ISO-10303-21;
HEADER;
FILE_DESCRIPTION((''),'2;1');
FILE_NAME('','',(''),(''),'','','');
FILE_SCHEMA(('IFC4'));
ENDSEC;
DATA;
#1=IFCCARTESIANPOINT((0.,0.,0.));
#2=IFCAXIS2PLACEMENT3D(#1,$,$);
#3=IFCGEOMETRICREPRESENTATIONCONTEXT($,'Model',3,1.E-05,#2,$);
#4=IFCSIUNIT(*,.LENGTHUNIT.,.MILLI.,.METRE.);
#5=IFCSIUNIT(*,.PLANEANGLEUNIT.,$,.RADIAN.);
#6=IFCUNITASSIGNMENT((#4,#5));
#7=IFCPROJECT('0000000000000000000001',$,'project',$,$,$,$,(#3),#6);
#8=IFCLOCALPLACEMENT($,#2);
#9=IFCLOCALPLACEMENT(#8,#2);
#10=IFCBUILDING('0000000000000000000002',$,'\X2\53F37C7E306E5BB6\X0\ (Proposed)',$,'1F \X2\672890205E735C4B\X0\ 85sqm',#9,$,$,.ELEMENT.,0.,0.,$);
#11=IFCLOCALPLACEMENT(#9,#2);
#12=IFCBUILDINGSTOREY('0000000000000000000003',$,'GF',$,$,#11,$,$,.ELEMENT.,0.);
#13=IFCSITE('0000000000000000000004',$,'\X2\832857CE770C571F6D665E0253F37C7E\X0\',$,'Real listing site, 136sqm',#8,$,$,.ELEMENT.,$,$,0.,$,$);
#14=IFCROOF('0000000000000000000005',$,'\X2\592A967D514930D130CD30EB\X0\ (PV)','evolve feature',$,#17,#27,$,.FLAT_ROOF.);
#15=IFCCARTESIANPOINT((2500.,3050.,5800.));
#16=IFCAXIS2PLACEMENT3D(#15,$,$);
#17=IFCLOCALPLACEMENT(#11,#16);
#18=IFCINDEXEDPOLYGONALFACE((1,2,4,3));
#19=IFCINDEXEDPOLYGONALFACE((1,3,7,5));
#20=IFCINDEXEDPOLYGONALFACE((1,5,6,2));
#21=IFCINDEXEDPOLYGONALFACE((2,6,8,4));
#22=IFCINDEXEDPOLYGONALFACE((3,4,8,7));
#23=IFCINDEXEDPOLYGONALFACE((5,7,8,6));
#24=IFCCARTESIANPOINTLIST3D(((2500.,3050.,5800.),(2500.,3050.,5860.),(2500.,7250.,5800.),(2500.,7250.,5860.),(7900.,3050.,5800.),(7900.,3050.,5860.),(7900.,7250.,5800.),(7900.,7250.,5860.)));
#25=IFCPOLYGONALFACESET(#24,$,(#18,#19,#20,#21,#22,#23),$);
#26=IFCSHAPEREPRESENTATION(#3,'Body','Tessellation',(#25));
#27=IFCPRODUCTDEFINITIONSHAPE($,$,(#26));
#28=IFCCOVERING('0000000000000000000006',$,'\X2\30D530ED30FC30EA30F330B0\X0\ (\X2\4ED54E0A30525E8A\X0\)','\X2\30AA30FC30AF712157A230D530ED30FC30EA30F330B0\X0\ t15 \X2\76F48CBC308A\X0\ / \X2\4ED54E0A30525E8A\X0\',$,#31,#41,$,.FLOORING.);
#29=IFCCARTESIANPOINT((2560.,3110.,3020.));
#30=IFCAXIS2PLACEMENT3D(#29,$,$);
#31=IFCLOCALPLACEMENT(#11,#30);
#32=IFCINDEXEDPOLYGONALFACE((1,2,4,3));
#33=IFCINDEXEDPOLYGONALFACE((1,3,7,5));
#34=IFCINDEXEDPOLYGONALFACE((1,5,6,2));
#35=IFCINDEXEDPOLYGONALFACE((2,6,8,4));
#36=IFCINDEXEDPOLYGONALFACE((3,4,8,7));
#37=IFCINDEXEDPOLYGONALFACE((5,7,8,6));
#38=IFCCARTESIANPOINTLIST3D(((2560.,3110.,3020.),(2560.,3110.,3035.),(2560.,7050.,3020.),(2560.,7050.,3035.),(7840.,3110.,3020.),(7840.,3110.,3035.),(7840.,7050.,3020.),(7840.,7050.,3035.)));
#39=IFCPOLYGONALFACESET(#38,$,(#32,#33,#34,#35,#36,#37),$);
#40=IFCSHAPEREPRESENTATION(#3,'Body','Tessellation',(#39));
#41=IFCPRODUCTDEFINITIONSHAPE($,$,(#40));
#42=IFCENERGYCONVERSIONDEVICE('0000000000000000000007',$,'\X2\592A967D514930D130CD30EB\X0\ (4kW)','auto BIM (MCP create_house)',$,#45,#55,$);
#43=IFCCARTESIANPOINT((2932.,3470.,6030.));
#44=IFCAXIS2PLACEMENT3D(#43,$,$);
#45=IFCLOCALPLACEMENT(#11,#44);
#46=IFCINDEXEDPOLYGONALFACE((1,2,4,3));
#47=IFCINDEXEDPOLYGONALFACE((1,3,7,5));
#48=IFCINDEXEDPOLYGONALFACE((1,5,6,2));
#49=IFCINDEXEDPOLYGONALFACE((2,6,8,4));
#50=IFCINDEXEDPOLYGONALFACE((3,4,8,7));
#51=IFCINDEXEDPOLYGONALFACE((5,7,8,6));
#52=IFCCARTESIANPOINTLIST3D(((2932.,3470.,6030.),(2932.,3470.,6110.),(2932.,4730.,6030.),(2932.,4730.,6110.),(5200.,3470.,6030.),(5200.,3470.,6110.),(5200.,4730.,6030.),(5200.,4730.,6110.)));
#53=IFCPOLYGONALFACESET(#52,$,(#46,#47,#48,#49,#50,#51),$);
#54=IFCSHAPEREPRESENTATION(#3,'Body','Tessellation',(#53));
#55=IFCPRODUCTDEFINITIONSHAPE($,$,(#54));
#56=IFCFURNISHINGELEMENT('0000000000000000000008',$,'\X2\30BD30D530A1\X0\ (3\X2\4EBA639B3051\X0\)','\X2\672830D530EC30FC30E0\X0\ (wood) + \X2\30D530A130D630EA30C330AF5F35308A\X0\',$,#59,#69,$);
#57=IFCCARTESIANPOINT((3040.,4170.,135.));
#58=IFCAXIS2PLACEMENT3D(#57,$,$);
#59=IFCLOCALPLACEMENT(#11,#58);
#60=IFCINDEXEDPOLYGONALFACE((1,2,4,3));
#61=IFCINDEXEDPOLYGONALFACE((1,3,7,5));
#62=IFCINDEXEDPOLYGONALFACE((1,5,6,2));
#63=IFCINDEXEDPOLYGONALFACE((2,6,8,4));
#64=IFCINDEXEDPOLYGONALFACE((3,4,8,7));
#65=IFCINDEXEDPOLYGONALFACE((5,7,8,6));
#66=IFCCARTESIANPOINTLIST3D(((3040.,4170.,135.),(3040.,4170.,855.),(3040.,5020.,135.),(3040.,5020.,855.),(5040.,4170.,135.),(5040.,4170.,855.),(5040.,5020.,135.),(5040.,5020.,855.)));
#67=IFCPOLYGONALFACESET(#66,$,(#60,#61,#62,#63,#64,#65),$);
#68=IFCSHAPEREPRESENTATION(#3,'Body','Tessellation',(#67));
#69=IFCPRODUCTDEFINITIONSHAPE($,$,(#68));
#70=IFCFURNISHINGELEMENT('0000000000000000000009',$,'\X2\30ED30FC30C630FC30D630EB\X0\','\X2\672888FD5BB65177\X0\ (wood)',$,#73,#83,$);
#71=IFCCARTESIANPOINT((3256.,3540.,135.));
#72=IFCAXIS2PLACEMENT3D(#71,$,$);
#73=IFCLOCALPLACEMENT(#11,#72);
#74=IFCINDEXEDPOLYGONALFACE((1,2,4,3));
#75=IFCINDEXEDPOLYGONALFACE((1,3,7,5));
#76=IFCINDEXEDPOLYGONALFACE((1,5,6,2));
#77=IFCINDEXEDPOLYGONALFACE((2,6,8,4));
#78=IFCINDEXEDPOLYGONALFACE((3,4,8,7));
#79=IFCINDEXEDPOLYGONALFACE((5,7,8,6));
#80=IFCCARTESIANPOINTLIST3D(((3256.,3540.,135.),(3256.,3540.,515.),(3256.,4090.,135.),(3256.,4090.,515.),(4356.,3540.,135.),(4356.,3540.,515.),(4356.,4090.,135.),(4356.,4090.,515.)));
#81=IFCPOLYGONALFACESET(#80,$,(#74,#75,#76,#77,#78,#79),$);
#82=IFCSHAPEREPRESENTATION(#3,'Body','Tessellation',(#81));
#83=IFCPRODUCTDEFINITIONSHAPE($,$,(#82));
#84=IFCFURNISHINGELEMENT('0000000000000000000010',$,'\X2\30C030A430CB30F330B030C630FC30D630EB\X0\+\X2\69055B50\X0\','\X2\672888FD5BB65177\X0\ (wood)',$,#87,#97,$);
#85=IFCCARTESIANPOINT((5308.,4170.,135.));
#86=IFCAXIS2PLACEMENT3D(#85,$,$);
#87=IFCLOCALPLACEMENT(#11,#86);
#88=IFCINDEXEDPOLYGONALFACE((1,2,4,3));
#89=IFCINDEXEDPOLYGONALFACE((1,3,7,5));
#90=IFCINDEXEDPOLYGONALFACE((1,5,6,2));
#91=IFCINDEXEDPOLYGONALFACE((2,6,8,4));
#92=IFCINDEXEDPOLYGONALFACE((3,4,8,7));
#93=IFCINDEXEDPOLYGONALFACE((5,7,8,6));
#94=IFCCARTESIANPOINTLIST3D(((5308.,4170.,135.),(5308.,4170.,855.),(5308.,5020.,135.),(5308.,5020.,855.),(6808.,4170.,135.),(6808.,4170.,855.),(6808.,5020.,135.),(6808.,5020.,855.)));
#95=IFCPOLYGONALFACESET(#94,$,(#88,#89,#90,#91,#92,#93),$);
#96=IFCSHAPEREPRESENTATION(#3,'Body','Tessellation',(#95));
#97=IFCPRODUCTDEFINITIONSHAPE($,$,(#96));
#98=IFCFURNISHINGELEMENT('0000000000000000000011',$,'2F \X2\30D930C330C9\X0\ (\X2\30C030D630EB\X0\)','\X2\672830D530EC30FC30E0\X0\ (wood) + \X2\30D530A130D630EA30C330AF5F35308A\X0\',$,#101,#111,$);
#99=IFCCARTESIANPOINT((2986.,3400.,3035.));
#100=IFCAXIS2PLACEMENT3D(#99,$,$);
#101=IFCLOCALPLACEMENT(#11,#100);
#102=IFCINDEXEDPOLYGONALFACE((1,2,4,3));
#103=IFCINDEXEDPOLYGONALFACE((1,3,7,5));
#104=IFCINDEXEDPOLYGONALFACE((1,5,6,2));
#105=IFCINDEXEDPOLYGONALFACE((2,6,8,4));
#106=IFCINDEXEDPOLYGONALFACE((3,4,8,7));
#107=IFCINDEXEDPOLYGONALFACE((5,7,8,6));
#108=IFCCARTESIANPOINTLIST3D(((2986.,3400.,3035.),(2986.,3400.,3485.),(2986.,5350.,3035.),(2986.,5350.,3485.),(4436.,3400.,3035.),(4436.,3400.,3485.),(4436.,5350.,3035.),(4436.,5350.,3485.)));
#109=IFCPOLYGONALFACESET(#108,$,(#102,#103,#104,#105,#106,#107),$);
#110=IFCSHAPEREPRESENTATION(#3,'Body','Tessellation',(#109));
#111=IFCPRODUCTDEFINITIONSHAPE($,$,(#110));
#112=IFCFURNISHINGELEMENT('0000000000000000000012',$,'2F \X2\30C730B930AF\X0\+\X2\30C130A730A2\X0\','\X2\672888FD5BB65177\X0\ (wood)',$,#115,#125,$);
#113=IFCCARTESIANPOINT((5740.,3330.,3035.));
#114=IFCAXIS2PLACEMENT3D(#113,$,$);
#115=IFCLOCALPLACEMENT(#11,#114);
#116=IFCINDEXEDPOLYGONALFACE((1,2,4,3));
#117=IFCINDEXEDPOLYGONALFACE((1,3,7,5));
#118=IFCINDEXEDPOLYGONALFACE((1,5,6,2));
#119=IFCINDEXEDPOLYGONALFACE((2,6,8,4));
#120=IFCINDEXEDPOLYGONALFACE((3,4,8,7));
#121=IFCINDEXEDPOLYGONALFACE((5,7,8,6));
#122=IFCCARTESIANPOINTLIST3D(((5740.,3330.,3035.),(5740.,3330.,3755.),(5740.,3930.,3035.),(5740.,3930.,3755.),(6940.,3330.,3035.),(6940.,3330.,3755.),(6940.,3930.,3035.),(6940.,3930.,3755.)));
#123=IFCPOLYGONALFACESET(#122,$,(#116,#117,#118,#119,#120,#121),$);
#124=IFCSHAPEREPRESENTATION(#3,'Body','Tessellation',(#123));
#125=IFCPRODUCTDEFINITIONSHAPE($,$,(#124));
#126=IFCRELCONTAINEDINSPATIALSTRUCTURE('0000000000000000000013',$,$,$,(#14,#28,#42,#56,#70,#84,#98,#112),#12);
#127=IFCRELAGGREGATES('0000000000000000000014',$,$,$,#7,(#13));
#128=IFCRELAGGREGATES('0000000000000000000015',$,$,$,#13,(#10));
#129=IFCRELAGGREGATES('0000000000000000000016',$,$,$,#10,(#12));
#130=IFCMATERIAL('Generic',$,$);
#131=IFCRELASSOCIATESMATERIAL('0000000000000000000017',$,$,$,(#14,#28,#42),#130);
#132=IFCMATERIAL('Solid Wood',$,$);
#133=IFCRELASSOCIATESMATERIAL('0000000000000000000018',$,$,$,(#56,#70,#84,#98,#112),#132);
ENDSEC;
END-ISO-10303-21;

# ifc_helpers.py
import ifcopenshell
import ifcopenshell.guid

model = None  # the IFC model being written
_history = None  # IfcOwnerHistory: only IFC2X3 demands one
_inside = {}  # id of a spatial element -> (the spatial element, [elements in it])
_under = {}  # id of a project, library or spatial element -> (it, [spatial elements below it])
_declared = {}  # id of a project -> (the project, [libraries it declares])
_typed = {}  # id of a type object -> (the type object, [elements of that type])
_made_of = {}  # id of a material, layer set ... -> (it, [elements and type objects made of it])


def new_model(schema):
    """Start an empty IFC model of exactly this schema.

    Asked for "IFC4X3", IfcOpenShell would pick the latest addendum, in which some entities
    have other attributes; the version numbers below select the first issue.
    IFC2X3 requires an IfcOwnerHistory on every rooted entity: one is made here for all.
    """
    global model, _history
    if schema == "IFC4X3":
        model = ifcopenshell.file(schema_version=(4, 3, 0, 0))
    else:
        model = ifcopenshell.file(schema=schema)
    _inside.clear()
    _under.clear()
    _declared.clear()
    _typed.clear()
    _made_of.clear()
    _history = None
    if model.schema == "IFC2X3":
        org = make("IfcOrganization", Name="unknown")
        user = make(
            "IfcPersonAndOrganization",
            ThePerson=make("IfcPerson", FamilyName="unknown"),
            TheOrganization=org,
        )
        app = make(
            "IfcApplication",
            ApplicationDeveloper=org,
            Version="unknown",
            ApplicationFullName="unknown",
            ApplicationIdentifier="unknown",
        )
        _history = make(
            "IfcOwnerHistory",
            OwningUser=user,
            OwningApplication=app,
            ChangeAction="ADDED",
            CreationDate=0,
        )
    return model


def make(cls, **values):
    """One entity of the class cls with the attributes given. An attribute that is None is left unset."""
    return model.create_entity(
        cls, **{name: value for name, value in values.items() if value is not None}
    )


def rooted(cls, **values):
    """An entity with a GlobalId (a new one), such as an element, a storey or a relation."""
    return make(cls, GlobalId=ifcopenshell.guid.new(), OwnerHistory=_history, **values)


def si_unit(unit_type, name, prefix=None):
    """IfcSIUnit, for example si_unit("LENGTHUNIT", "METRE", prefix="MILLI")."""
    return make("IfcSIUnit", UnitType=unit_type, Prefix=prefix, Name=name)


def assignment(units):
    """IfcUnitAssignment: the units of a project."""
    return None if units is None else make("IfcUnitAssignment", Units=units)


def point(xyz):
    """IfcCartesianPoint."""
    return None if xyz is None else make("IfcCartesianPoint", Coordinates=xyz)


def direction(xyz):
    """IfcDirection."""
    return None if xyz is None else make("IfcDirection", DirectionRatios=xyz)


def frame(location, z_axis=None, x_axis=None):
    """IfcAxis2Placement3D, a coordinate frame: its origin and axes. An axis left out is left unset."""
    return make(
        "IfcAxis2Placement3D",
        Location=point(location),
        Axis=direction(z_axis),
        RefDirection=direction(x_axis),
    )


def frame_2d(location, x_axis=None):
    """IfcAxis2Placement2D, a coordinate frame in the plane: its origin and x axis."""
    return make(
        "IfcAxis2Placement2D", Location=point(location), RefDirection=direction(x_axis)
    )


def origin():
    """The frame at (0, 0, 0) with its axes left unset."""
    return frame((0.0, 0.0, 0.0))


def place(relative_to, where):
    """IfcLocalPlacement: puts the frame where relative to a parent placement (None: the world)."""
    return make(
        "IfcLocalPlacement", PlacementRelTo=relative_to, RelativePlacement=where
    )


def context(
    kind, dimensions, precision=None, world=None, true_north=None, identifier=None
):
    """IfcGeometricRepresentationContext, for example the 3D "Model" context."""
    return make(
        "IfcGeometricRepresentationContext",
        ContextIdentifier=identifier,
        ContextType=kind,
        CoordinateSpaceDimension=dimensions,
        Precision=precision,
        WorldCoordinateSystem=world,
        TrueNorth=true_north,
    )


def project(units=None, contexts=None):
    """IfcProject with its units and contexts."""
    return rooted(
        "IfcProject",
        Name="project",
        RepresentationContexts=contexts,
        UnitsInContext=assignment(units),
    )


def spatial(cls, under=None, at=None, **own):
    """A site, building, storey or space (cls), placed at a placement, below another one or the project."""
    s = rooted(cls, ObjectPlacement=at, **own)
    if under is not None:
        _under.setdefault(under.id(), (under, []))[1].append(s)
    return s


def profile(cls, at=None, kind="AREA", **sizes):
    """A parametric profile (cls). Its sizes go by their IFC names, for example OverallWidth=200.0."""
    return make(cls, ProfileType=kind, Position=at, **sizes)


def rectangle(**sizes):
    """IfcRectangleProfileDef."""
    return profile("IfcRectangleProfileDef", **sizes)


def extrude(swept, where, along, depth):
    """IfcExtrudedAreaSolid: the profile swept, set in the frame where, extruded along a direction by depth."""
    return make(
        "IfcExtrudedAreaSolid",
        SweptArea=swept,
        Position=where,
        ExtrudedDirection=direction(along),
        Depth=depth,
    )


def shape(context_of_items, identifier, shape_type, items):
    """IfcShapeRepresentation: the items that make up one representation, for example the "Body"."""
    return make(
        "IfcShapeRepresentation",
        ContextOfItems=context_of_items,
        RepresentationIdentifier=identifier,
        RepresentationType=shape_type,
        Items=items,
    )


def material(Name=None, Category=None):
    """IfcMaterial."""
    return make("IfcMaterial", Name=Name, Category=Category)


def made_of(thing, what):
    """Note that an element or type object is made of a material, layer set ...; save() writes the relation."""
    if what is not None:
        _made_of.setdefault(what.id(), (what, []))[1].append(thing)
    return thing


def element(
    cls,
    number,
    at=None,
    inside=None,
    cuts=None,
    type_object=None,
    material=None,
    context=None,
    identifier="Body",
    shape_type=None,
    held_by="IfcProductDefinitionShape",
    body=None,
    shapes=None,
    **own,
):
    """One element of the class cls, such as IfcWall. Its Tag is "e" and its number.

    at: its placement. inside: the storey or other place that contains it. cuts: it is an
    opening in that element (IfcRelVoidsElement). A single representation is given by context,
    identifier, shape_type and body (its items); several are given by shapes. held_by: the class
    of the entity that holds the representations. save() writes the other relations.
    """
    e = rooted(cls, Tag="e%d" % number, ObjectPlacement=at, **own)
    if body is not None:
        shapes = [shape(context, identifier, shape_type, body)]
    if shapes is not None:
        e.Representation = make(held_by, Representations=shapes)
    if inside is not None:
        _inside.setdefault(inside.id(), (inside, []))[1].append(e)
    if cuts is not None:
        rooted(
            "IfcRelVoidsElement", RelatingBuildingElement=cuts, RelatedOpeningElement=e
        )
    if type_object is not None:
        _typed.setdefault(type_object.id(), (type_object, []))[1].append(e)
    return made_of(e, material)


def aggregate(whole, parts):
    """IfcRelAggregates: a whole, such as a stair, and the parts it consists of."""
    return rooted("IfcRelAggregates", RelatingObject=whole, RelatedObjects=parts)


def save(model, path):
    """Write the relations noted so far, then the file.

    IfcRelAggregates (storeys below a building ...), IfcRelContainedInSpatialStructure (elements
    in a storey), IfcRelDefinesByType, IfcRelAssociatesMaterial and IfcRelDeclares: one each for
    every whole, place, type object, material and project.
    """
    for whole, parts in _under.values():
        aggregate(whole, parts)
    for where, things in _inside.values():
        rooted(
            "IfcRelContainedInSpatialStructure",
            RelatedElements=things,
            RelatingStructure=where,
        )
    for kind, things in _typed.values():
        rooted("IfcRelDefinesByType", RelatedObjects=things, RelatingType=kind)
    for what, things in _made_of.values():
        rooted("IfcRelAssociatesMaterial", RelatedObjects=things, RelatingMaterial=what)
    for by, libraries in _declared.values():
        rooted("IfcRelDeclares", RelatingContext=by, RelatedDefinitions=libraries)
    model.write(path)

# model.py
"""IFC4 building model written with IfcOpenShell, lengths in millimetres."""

from ifc_helpers import new_model, si_unit, frame, frame_2d, origin, place, context, project, spatial, rectangle, extrude, material, element, save


model = new_model("IFC4")

# Units and contexts
model_context = context("Model", 3, precision=1e-05, world=origin())
ifc_project = project(units=[si_unit("LENGTHUNIT", "METRE", prefix="MILLI"), si_unit("PLANEANGLEUNIT", "RADIAN")], contexts=[model_context])

# Site, building, storey
site_placement = place(None, origin())
site = spatial("IfcSite", under=ifc_project, at=site_placement, Name="茨城県土浦市右籾", ObjectType="Real listing site, 136sqm", CompositionType="ELEMENT", RefElevation=0.0)
building_placement = place(site_placement, origin())
building = spatial("IfcBuilding", under=site, at=building_placement, Name="右籾の家 (Proposed)", ObjectType="1F 木造平屋 85sqm", CompositionType="ELEMENT", ElevationOfRefHeight=0.0, ElevationOfTerrain=0.0)
storey_placement = place(building_placement, origin())
storey = spatial("IfcBuildingStorey", under=building, at=storey_placement, Name="GF", CompositionType="ELEMENT", Elevation=0.0)

# Shared definitions
ifc_material_1 = material(Name="Solid Wood")

# Shared definitions
ifc_material_2 = material(Name="Generic")

# Roof
roof_placement = place(storey_placement, frame((2500.0, 3050.0, 5800.0)))
element("IfcRoof", 1, at=roof_placement, inside=storey, material=ifc_material_2, Name="太陽光パネル (PV)", Description="evolve feature", PredefinedType="FLAT_ROOF", context=model_context, shape_type="SweptSolid", body=[
    extrude(rectangle(XDim=5400.0, YDim=4200.0, at=frame_2d((2700.0, 2100.0))), frame((2500.0, 3050.0, 5800.0)), (0.0, 0.0, 1.0), 60.0),
])

# Covering
covering_placement = place(storey_placement, frame((2560.0, 3110.0, 3020.0)))
element("IfcCovering", 2, at=covering_placement, inside=storey, material=ifc_material_2, Name="フローリング (仕上げ床)", Description="オーク無垢フローリング t15 直貼り / 仕上げ床", PredefinedType="FLOORING", context=model_context, shape_type="SweptSolid", body=[
    extrude(rectangle(XDim=5280.0, YDim=3940.0, at=frame_2d((2640.0, 1970.0))), frame((2560.0, 3110.0, 3020.0)), (0.0, 0.0, 1.0), 15.0),
])

# Energy conversion device
energy_conversion_device_placement = place(storey_placement, frame((2932.0, 3470.0, 6030.0)))
element("IfcEnergyConversionDevice", 3, at=energy_conversion_device_placement, inside=storey, material=ifc_material_2, Name="太陽光パネル (4kW)", Description="auto BIM (MCP create_house)", context=model_context, shape_type="SweptSolid", body=[
    extrude(rectangle(XDim=2268.0, YDim=1260.0, at=frame_2d((1134.0, 630.0))), frame((2932.0, 3470.0, 6030.0)), (0.0, 0.0, 1.0), 80.0),
])

# Furnishing elements
furnishing_1_placement = place(storey_placement, frame((3040.0, 4170.0, 135.0)))
element("IfcFurnishingElement", 4, at=furnishing_1_placement, inside=storey, material=ifc_material_1, Name="ソファ (3人掛け)", Description="木フレーム (wood) + ファブリック張り", context=model_context, shape_type="SweptSolid", body=[
    extrude(rectangle(XDim=2000.0, YDim=850.0, at=frame_2d((1000.0, 425.0))), frame((3040.0, 4170.0, 135.0)), (0.0, 0.0, 1.0), 720.0),
])
furnishing_2_placement = place(storey_placement, frame((3256.0, 3540.0, 135.0)))
element("IfcFurnishingElement", 5, at=furnishing_2_placement, inside=storey, material=ifc_material_1, Name="ローテーブル", Description="木製家具 (wood)", context=model_context, shape_type="SweptSolid", body=[
    extrude(rectangle(XDim=1100.0, YDim=550.0, at=frame_2d((550.0, 275.0))), frame((3256.0, 3540.0, 135.0)), (0.0, 0.0, 1.0), 380.0),
])
furnishing_3_placement = place(storey_placement, frame((5308.0, 4170.0, 135.0)))
element("IfcFurnishingElement", 6, at=furnishing_3_placement, inside=storey, material=ifc_material_1, Name="ダイニングテーブル+椅子", Description="木製家具 (wood)", context=model_context, shape_type="SweptSolid", body=[
    extrude(rectangle(XDim=1500.0, YDim=850.0, at=frame_2d((750.0, 425.0))), frame((5308.0, 4170.0, 135.0)), (0.0, 0.0, 1.0), 720.0),
])
furnishing_4_placement = place(storey_placement, frame((2986.0, 3400.0, 3035.0)))
element("IfcFurnishingElement", 7, at=furnishing_4_placement, inside=storey, material=ifc_material_1, Name="2F ベッド (ダブル)", Description="木フレーム (wood) + ファブリック張り", context=model_context, shape_type="SweptSolid", body=[
    extrude(rectangle(XDim=1450.0, YDim=1950.0, at=frame_2d((725.0, 975.0))), frame((2986.0, 3400.0, 3035.0)), (0.0, 0.0, 1.0), 450.0),
])
furnishing_5_placement = place(storey_placement, frame((5740.0, 3330.0, 3035.0)))
element("IfcFurnishingElement", 8, at=furnishing_5_placement, inside=storey, material=ifc_material_1, Name="2F デスク+チェア", Description="木製家具 (wood)", context=model_context, shape_type="SweptSolid", body=[
    extrude(rectangle(XDim=1200.0, YDim=600.0, at=frame_2d((600.0, 300.0))), frame((5740.0, 3330.0, 3035.0)), (0.0, 0.0, 1.0), 720.0),
])

save(model, "model.ifc")
